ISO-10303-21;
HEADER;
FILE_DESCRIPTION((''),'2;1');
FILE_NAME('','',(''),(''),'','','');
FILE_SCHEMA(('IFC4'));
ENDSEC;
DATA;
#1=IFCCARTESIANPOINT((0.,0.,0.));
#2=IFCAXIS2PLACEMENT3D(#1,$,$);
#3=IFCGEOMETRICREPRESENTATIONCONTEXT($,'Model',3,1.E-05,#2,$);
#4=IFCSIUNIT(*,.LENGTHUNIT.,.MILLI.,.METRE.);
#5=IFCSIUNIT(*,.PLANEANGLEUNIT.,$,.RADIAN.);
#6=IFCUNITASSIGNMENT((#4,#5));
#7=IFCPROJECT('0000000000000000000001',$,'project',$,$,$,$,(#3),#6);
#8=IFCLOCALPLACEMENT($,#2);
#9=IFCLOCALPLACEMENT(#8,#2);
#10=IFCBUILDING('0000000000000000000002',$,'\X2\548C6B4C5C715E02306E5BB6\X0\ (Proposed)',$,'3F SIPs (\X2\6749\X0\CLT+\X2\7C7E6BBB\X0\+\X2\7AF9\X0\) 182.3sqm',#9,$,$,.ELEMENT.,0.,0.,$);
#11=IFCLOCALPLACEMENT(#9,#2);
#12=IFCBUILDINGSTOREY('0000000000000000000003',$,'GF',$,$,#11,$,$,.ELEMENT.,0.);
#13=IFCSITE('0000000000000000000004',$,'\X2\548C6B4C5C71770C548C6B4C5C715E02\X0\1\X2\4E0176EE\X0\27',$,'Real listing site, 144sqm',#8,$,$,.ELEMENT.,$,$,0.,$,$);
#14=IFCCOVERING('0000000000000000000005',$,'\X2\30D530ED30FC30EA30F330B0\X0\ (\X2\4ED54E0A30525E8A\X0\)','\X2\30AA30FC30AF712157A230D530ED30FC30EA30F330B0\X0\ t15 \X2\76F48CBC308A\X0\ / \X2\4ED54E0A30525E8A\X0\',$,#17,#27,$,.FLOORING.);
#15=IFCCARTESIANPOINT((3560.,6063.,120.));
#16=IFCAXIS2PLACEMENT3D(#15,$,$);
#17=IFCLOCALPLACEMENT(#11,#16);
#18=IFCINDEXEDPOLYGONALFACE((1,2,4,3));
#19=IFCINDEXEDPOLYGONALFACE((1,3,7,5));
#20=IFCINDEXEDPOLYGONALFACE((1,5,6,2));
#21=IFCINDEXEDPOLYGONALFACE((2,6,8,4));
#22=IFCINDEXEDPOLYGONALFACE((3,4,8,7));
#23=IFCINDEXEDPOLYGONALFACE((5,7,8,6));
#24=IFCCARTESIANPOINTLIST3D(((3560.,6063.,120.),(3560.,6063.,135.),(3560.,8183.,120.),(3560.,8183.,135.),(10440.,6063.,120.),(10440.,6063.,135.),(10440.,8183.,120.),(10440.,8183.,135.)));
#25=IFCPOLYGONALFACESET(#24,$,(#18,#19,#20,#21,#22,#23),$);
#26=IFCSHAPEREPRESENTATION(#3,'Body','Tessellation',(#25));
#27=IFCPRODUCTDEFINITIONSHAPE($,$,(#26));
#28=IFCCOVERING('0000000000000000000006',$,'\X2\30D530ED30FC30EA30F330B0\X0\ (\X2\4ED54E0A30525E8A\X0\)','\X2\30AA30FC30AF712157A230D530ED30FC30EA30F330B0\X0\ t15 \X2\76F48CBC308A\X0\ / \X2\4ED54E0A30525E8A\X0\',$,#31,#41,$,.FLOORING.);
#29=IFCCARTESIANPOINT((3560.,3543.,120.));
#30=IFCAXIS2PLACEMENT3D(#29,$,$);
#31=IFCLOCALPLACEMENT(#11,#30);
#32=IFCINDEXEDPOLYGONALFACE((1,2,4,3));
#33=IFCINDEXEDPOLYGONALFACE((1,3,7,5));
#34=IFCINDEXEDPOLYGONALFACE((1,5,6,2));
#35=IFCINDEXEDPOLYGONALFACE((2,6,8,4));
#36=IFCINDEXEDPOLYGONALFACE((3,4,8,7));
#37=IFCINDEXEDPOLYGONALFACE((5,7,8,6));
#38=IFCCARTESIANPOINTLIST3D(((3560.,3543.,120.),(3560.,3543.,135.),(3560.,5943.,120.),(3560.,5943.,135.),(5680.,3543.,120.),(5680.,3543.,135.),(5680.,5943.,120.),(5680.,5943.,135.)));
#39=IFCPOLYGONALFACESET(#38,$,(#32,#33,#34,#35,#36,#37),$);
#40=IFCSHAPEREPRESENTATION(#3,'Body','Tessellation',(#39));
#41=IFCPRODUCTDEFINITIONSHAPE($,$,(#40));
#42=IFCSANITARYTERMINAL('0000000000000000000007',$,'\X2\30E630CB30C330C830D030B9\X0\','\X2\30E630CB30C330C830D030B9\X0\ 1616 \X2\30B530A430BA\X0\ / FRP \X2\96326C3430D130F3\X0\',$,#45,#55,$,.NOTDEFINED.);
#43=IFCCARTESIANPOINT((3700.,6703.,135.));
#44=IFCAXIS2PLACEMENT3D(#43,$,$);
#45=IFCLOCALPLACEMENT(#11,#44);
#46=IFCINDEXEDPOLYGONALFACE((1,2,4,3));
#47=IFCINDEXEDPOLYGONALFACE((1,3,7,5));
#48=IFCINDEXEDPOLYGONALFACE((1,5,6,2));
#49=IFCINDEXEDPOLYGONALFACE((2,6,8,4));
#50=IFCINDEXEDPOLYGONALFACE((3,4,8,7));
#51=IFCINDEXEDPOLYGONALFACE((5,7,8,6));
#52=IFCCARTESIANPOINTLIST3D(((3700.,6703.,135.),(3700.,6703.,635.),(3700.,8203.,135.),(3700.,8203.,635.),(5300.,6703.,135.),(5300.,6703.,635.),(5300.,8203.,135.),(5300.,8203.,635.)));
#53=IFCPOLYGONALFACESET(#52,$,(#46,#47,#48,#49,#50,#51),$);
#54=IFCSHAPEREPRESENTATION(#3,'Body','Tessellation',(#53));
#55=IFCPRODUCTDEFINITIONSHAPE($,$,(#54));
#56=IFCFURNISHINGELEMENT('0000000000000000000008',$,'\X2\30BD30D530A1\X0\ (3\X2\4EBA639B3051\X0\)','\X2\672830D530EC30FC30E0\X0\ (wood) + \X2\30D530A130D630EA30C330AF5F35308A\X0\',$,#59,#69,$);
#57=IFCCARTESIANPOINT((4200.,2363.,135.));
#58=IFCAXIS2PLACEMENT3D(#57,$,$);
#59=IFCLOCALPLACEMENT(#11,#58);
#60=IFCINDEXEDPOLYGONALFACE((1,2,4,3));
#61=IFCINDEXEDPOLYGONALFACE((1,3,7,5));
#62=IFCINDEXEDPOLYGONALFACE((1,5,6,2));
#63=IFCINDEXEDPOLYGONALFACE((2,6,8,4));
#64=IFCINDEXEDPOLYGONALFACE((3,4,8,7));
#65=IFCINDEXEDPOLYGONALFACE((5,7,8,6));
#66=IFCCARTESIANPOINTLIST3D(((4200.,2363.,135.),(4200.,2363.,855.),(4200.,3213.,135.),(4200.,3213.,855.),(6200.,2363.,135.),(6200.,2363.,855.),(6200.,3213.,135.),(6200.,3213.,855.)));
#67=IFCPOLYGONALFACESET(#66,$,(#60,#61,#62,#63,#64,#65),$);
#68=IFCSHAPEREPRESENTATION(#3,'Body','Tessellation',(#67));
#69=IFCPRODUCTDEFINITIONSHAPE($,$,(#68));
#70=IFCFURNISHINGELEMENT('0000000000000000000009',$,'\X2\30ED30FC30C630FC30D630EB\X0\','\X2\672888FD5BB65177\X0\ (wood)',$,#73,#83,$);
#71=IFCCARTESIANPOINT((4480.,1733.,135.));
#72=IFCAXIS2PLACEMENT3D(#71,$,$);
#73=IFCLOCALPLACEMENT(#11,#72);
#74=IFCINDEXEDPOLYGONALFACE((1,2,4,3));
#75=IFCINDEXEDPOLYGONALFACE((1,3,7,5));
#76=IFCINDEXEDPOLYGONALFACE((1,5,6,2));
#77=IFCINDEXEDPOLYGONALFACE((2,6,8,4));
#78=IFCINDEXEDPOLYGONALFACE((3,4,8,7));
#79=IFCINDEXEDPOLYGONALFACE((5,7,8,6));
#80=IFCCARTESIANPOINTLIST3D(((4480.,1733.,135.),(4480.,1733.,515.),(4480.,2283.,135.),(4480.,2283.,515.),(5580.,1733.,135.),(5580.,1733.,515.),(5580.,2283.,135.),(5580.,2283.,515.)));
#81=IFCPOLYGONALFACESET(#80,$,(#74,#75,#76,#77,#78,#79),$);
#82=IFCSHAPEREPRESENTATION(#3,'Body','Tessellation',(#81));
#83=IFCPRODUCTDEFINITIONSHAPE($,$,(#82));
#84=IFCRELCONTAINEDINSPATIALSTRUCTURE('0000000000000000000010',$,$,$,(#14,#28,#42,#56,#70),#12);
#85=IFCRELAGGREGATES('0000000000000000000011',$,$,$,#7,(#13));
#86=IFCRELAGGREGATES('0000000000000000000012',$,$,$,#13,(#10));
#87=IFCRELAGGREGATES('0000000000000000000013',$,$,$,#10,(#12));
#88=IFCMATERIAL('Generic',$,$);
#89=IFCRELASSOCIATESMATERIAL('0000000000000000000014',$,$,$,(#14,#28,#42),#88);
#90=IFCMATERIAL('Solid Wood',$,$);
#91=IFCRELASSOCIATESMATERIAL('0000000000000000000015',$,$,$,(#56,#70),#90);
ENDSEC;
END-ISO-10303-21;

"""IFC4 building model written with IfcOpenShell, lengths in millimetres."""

from ifc_helpers import new_model, si_unit, frame, frame_2d, origin, place, context, project, spatial, rectangle, extrude, material, element, save


model = new_model("IFC4")

# Units and contexts
model_context = context("Model", 3, precision=1e-05, world=origin())
ifc_project = project(units=[si_unit("LENGTHUNIT", "METRE", prefix="MILLI"), si_unit("PLANEANGLEUNIT", "RADIAN")], contexts=[model_context])

# Site, building, storey
site_placement = place(None, origin())
site = spatial("IfcSite", under=ifc_project, at=site_placement, Name="和歌山県和歌山市1丁目27", ObjectType="Real listing site, 144sqm", CompositionType="ELEMENT", RefElevation=0.0)
building_placement = place(site_placement, origin())
building = spatial("IfcBuilding", under=site, at=building_placement, Name="和歌山市の家 (Proposed)", ObjectType="3F SIPs (杉CLT+籾殻+竹) 182.3sqm", CompositionType="ELEMENT", ElevationOfRefHeight=0.0, ElevationOfTerrain=0.0)
storey_placement = place(building_placement, origin())
storey = spatial("IfcBuildingStorey", under=building, at=storey_placement, Name="GF", CompositionType="ELEMENT", Elevation=0.0)

# Shared definitions
ifc_material_1 = material(Name="Solid Wood")

# Coverings
ifc_material_2 = material(Name="Generic")
covering_1_placement = place(storey_placement, frame((3560.0, 6063.0, 120.0)))
element("IfcCovering", 1, at=covering_1_placement, inside=storey, material=ifc_material_2, Name="フローリング (仕上げ床)", Description="オーク無垢フローリング t15 直貼り / 仕上げ床", PredefinedType="FLOORING", context=model_context, shape_type="SweptSolid", body=[
    extrude(rectangle(XDim=6880.0, YDim=2120.0, at=frame_2d((3440.0, 1060.0))), frame((3560.0, 6063.0, 120.0)), (0.0, 0.0, 1.0), 15.0),
])
covering_2_placement = place(storey_placement, frame((3560.0, 3543.0, 120.0)))
element("IfcCovering", 2, at=covering_2_placement, inside=storey, material=ifc_material_2, Name="フローリング (仕上げ床)", Description="オーク無垢フローリング t15 直貼り / 仕上げ床", PredefinedType="FLOORING", context=model_context, shape_type="SweptSolid", body=[
    extrude(rectangle(XDim=2120.0, YDim=2400.0, at=frame_2d((1060.0, 1200.0))), frame((3560.0, 3543.0, 120.0)), (0.0, 0.0, 1.0), 15.0),
])

# Sanitary terminal
sanitary_terminal_placement = place(storey_placement, frame((3700.0, 6703.0, 135.0)))
element("IfcSanitaryTerminal", 3, at=sanitary_terminal_placement, inside=storey, material=ifc_material_2, Name="ユニットバス", Description="ユニットバス 1616 サイズ / FRP 防水パン", PredefinedType="NOTDEFINED", context=model_context, shape_type="SweptSolid", body=[
    extrude(rectangle(XDim=1600.0, YDim=1500.0, at=frame_2d((800.0, 750.0))), frame((3700.0, 6703.0, 135.0)), (0.0, 0.0, 1.0), 500.0),
])

# Furnishing elements
furnishing_1_placement = place(storey_placement, frame((4200.0, 2363.0, 135.0)))
element("IfcFurnishingElement", 4, at=furnishing_1_placement, inside=storey, material=ifc_material_1, Name="ソファ (3人掛け)", Description="木フレーム (wood) + ファブリック張り", context=model_context, shape_type="SweptSolid", body=[
    extrude(rectangle(XDim=2000.0, YDim=850.0, at=frame_2d((1000.0, 425.0))), frame((4200.0, 2363.0, 135.0)), (0.0, 0.0, 1.0), 720.0),
])
furnishing_2_placement = place(storey_placement, frame((4480.0, 1733.0, 135.0)))
element("IfcFurnishingElement", 5, at=furnishing_2_placement, inside=storey, material=ifc_material_1, Name="ローテーブル", Description="木製家具 (wood)", context=model_context, shape_type="SweptSolid", body=[
    extrude(rectangle(XDim=1100.0, YDim=550.0, at=frame_2d((550.0, 275.0))), frame((4480.0, 1733.0, 135.0)), (0.0, 0.0, 1.0), 380.0),
])

save(model, "model.ifc")
